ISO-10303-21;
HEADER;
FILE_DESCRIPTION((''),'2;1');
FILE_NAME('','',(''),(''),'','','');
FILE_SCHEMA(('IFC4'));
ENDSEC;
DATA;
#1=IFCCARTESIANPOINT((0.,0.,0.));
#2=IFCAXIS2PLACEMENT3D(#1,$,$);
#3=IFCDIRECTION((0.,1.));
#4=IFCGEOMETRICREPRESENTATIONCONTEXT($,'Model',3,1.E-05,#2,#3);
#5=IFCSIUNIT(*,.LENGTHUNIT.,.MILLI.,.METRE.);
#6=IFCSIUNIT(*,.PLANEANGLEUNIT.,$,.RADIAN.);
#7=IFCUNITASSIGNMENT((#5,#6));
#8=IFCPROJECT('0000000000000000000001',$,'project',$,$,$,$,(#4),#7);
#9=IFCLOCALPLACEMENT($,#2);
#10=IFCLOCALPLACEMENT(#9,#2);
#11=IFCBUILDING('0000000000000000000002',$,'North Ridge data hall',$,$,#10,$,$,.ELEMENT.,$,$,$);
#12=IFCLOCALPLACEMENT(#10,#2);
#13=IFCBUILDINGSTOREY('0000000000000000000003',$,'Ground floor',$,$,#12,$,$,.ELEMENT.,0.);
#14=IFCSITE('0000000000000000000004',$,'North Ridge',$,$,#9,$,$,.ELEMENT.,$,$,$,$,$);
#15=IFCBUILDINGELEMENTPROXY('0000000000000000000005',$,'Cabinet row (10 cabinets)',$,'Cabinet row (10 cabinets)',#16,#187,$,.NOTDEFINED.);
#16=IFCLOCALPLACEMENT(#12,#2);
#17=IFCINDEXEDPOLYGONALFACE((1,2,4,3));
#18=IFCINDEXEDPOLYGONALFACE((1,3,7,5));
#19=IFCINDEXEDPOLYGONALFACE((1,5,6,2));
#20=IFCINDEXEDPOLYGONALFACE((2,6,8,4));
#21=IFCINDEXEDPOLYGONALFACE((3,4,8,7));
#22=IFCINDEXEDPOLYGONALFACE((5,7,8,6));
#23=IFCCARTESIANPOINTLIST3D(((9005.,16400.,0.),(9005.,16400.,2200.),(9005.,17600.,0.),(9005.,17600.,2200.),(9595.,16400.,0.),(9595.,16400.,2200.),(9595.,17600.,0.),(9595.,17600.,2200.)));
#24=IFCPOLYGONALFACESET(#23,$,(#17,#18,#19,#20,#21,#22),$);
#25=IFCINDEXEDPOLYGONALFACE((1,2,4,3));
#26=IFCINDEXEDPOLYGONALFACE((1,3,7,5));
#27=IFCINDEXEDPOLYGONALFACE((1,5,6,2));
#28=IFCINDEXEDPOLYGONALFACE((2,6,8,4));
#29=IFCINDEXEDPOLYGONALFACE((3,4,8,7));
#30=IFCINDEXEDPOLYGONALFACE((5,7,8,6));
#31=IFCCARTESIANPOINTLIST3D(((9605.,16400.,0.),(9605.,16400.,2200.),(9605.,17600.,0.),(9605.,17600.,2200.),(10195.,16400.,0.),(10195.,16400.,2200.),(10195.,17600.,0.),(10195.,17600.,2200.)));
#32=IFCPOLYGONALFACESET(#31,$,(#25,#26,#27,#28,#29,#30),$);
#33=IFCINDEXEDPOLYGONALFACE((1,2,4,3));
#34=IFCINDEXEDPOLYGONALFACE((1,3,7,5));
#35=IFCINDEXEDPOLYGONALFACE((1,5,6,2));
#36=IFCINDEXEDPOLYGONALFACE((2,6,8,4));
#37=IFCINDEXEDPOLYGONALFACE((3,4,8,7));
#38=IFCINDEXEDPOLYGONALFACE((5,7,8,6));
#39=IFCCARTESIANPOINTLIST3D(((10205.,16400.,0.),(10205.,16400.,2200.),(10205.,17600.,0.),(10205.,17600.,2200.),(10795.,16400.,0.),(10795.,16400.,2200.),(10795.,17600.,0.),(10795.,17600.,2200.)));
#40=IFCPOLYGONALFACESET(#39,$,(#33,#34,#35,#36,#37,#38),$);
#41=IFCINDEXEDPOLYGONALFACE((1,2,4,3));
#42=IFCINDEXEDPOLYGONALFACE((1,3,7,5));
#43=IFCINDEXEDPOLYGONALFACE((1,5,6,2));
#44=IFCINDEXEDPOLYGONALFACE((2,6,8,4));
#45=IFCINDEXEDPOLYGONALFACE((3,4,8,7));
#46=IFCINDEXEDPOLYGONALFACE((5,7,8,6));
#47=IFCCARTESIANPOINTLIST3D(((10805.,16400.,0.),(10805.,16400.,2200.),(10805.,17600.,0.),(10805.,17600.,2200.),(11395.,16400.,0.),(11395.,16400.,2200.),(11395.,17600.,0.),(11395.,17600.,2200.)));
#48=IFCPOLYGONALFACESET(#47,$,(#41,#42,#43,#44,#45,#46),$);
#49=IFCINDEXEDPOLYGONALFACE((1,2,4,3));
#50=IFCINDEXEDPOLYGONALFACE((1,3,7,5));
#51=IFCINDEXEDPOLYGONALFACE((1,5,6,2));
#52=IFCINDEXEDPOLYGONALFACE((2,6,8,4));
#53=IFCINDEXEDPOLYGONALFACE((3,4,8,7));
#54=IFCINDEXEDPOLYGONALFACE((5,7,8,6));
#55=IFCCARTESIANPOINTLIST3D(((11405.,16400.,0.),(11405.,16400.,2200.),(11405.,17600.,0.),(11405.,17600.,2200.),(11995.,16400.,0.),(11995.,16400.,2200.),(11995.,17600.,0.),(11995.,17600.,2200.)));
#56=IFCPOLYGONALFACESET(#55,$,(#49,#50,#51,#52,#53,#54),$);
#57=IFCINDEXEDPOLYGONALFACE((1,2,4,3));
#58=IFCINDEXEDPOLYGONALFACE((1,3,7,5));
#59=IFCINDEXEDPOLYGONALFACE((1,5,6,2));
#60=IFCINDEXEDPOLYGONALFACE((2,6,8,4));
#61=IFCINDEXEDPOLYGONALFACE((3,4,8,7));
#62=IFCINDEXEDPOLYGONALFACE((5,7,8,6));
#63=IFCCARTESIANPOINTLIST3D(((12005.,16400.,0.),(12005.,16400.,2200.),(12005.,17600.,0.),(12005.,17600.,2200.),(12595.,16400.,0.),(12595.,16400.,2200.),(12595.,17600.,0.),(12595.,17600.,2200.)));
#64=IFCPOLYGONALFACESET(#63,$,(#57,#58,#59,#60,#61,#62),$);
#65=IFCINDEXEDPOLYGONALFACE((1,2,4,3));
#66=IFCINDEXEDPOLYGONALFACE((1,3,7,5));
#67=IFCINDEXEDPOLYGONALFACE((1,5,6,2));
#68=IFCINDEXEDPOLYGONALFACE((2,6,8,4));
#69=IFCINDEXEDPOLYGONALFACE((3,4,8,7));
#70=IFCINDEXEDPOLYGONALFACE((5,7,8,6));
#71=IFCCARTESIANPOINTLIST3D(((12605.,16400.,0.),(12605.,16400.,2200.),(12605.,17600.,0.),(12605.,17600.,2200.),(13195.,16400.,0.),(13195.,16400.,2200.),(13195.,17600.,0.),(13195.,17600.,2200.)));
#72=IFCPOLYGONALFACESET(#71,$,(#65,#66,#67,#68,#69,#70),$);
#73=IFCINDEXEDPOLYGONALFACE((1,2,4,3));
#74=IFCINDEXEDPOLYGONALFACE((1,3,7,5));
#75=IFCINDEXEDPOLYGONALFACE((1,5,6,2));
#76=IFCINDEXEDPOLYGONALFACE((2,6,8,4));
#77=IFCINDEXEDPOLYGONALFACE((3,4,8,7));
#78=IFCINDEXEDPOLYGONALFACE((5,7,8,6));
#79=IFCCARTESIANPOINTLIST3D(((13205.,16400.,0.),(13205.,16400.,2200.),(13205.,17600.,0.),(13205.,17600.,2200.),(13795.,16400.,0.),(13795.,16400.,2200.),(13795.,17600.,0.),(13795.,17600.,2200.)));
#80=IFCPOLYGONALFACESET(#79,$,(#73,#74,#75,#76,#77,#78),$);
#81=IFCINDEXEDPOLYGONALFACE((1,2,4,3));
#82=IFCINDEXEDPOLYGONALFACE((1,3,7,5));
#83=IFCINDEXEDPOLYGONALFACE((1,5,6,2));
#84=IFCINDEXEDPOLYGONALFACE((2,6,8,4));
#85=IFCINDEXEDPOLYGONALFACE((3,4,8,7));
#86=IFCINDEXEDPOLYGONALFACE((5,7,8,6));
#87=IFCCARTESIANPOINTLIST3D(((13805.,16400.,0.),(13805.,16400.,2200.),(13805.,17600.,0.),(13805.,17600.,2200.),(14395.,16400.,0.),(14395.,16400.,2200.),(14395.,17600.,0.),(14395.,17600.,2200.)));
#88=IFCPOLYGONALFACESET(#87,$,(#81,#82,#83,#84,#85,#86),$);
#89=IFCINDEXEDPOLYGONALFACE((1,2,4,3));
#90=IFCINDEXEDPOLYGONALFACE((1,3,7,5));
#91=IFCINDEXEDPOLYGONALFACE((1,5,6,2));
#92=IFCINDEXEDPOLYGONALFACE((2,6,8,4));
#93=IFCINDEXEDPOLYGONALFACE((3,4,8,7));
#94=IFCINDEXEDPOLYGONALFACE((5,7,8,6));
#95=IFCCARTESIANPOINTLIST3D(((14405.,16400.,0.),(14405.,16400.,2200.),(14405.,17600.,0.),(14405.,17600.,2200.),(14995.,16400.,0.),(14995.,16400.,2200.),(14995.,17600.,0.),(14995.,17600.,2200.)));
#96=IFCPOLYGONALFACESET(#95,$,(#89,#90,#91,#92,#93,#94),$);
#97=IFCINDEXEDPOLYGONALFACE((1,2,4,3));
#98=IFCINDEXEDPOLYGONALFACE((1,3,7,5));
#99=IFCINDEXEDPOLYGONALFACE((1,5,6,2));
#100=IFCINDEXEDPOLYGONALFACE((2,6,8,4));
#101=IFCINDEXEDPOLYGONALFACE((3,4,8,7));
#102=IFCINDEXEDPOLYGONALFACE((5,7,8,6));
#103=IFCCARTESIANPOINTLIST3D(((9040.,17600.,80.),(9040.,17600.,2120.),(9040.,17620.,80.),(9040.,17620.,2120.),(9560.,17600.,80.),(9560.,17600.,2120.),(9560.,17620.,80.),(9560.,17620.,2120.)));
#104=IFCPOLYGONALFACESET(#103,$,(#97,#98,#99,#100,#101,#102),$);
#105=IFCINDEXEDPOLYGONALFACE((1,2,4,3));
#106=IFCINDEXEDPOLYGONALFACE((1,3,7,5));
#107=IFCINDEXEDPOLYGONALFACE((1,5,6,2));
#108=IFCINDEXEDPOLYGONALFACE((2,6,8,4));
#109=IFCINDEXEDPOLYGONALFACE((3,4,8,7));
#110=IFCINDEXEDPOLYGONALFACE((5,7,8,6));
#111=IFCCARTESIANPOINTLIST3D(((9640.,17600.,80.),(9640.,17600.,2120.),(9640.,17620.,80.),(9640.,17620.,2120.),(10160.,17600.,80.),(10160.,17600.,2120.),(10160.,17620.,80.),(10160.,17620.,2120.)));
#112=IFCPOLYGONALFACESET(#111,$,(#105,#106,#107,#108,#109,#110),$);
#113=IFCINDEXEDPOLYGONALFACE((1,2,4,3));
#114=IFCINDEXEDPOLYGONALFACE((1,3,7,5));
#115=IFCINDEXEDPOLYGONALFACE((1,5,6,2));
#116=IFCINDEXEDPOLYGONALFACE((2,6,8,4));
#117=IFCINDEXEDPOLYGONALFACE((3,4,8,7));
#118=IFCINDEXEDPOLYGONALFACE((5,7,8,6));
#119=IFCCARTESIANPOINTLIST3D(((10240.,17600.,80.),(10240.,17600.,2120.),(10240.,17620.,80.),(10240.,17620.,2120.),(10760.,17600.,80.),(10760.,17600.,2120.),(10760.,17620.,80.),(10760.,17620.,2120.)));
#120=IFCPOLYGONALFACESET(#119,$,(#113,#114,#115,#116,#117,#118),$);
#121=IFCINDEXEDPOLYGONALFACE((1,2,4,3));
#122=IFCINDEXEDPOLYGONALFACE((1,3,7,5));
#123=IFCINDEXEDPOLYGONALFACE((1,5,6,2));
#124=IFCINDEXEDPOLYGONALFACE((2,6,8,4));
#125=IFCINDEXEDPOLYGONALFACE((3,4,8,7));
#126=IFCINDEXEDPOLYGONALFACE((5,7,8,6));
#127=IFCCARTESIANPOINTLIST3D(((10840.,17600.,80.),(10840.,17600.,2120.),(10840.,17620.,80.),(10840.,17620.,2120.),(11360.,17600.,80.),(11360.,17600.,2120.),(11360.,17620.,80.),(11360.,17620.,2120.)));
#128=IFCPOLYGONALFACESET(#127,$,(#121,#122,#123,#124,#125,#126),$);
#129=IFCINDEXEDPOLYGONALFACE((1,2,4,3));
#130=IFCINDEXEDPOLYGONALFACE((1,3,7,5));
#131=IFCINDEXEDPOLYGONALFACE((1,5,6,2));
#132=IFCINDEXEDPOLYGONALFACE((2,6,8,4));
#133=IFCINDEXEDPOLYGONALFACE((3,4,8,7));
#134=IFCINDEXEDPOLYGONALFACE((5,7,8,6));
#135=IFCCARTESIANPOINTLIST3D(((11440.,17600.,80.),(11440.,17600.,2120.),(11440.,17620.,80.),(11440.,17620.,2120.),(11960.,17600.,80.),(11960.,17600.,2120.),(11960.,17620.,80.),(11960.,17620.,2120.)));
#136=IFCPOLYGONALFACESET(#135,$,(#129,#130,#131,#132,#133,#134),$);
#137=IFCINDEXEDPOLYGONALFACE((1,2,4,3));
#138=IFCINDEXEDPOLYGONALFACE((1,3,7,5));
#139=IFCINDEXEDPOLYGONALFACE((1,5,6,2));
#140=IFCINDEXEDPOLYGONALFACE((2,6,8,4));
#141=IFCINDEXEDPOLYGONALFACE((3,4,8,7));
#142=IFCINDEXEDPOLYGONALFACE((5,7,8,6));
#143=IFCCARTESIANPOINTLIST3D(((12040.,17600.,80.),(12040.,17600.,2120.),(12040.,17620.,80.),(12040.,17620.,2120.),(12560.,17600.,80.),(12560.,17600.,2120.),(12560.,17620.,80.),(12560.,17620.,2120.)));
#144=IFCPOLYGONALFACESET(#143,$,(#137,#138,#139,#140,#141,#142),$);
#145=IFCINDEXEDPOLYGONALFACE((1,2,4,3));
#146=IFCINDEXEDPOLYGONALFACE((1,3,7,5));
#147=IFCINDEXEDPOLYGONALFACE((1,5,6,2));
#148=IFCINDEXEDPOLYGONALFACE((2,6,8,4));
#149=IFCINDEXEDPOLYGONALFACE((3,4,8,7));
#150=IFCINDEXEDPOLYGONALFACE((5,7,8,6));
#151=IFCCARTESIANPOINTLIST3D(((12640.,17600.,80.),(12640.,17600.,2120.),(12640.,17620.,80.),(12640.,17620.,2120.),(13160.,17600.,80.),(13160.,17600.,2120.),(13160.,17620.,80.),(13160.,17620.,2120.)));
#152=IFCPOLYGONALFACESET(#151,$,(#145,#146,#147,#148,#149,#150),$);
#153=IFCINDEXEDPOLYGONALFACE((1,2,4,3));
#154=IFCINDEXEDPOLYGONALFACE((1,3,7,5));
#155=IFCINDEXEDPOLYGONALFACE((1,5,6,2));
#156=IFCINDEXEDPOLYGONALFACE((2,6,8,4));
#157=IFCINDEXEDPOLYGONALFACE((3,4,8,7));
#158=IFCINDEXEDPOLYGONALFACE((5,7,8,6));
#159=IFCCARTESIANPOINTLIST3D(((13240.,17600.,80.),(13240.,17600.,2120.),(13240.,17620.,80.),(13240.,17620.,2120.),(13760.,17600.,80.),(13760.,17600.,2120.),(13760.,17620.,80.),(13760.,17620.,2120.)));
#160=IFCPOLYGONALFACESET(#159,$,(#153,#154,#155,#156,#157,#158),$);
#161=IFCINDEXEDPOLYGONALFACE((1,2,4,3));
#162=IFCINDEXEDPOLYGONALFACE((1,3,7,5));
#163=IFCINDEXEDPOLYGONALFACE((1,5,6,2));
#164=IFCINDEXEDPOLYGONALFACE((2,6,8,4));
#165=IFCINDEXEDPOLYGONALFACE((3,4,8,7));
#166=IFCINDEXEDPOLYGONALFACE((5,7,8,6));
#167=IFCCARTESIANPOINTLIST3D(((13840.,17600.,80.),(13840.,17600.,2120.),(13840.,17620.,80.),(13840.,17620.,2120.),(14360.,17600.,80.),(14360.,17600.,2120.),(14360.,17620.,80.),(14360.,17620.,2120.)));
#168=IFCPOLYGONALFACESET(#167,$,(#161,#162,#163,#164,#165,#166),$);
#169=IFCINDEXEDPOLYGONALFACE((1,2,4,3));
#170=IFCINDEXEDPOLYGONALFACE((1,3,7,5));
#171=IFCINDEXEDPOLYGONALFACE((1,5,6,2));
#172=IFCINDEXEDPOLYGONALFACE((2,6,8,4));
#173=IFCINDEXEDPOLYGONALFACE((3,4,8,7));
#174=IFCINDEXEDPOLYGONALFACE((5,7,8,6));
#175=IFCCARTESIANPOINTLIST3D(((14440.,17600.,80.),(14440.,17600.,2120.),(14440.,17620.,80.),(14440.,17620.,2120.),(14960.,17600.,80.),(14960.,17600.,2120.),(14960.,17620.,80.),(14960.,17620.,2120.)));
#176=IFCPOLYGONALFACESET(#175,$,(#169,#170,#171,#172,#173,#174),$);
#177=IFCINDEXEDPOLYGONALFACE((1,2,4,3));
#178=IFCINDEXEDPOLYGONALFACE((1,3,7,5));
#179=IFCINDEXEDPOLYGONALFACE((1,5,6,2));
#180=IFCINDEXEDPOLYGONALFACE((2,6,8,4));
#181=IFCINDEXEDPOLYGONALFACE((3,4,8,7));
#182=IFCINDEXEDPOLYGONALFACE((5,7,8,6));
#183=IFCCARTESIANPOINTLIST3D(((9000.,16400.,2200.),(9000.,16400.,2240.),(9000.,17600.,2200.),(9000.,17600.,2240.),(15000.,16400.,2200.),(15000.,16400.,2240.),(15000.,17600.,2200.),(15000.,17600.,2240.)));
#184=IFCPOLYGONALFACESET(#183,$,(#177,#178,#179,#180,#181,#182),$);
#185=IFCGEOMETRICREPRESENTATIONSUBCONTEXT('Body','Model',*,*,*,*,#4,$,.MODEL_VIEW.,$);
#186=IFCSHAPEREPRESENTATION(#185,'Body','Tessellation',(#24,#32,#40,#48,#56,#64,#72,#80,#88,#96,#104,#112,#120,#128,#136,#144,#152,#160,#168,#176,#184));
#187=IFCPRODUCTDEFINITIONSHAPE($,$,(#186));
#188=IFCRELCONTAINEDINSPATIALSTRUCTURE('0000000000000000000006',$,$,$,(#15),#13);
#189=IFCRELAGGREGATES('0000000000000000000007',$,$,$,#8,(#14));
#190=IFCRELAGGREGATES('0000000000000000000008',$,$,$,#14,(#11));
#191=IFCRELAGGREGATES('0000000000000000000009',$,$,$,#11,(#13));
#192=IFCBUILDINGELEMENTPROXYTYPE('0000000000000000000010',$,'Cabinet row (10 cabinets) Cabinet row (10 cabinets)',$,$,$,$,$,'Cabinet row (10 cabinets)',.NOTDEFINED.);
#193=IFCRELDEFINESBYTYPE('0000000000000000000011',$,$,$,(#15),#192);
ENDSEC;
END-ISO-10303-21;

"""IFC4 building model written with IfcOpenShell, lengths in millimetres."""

from ifc_helpers import new_model, si_unit, direction, frame, origin, place, context, subcontext, project, spatial, polyline, outline, extrude, source, transform, mapped, type_object, type_shapes, element, save


model = new_model("IFC4")

# Units and contexts
model_context = context("Model", 3, precision=1e-05, world=origin(), true_north=direction((0.0, 1.0)))
body_context = subcontext(model_context, "Body", "Model", "MODEL_VIEW")
ifc_project = project(units=[si_unit("LENGTHUNIT", "METRE", prefix="MILLI"), si_unit("PLANEANGLEUNIT", "RADIAN")], contexts=[model_context])

# Site, building, storey
site_placement = place(None, origin())
site = spatial("IfcSite", under=ifc_project, at=site_placement, Name="North Ridge", CompositionType="ELEMENT")
building_placement = place(site_placement, origin())
building = spatial("IfcBuilding", under=site, at=building_placement, Name="North Ridge data hall", CompositionType="ELEMENT")
storey_placement = place(building_placement, origin())
storey = spatial("IfcBuildingStorey", under=building, at=storey_placement, Name="Ground floor", CompositionType="ELEMENT", Elevation=0.0)

# Building element proxy
building_element_proxy_type_1 = type_object("IfcBuildingElementProxyType", Name="Cabinet row (10 cabinets) Cabinet row (10 cabinets)", ElementType="Cabinet row (10 cabinets)", PredefinedType="NOTDEFINED")
shared_shape_1 = source(origin(), body_context, "Body", "SweptSolid", [
    extrude(outline(polyline([(5.0, 0.0), (595.0, 0.0), (595.0, 1200.0), (5.0, 1200.0), (5.0, 0.0)])), origin(), (0.0, 0.0, 1.0), 2200.0),
    extrude(outline(polyline([(605.0, 0.0), (1195.0, 0.0), (1195.0, 1200.0), (605.0, 1200.0), (605.0, 0.0)])), origin(), (0.0, 0.0, 1.0), 2200.0),
    extrude(outline(polyline([(1205.0, 0.0), (1795.0, 0.0), (1795.0, 1200.0), (1205.0, 1200.0), (1205.0, 0.0)])), origin(), (0.0, 0.0, 1.0), 2200.0),
    extrude(outline(polyline([(1805.0, 0.0), (2395.0, 0.0), (2395.0, 1200.0), (1805.0, 1200.0), (1805.0, 0.0)])), origin(), (0.0, 0.0, 1.0), 2200.0),
    extrude(outline(polyline([(2405.0, 0.0), (2995.0, 0.0), (2995.0, 1200.0), (2405.0, 1200.0), (2405.0, 0.0)])), origin(), (0.0, 0.0, 1.0), 2200.0),
    extrude(outline(polyline([(3005.0, 0.0), (3595.0, 0.0), (3595.0, 1200.0), (3005.0, 1200.0), (3005.0, 0.0)])), origin(), (0.0, 0.0, 1.0), 2200.0),
    extrude(outline(polyline([(3605.0, 0.0), (4195.0, 0.0), (4195.0, 1200.0), (3605.0, 1200.0), (3605.0, 0.0)])), origin(), (0.0, 0.0, 1.0), 2200.0),
    extrude(outline(polyline([(4205.0, 0.0), (4795.0, 0.0), (4795.0, 1200.0), (4205.0, 1200.0), (4205.0, 0.0)])), origin(), (0.0, 0.0, 1.0), 2200.0),
    extrude(outline(polyline([(4805.0, 0.0), (5395.0, 0.0), (5395.0, 1200.0), (4805.0, 1200.0), (4805.0, 0.0)])), origin(), (0.0, 0.0, 1.0), 2200.0),
    extrude(outline(polyline([(5405.0, 0.0), (5995.0, 0.0), (5995.0, 1200.0), (5405.0, 1200.0), (5405.0, 0.0)])), origin(), (0.0, 0.0, 1.0), 2200.0),
    extrude(outline(polyline([(40.0, 1200.0), (560.0, 1200.0), (560.0, 1220.0), (40.0, 1220.0), (40.0, 1200.0)])), frame((0.0, 0.0, 80.0)), (0.0, 0.0, 1.0), 2040.0),
    extrude(outline(polyline([(640.0, 1200.0), (1160.0, 1200.0), (1160.0, 1220.0), (640.0, 1220.0), (640.0, 1200.0)])), frame((0.0, 0.0, 80.0)), (0.0, 0.0, 1.0), 2040.0),
    extrude(outline(polyline([(1240.0, 1200.0), (1760.0, 1200.0), (1760.0, 1220.0), (1240.0, 1220.0), (1240.0, 1200.0)])), frame((0.0, 0.0, 80.0)), (0.0, 0.0, 1.0), 2040.0),
    extrude(outline(polyline([(1840.0, 1200.0), (2360.0, 1200.0), (2360.0, 1220.0), (1840.0, 1220.0), (1840.0, 1200.0)])), frame((0.0, 0.0, 80.0)), (0.0, 0.0, 1.0), 2040.0),
    extrude(outline(polyline([(2440.0, 1200.0), (2960.0, 1200.0), (2960.0, 1220.0), (2440.0, 1220.0), (2440.0, 1200.0)])), frame((0.0, 0.0, 80.0)), (0.0, 0.0, 1.0), 2040.0),
    extrude(outline(polyline([(3040.0, 1200.0), (3560.0, 1200.0), (3560.0, 1220.0), (3040.0, 1220.0), (3040.0, 1200.0)])), frame((0.0, 0.0, 80.0)), (0.0, 0.0, 1.0), 2040.0),
    extrude(outline(polyline([(3640.0, 1200.0), (4160.0, 1200.0), (4160.0, 1220.0), (3640.0, 1220.0), (3640.0, 1200.0)])), frame((0.0, 0.0, 80.0)), (0.0, 0.0, 1.0), 2040.0),
    extrude(outline(polyline([(4240.0, 1200.0), (4760.0, 1200.0), (4760.0, 1220.0), (4240.0, 1220.0), (4240.0, 1200.0)])), frame((0.0, 0.0, 80.0)), (0.0, 0.0, 1.0), 2040.0),
    extrude(outline(polyline([(4840.0, 1200.0), (5360.0, 1200.0), (5360.0, 1220.0), (4840.0, 1220.0), (4840.0, 1200.0)])), frame((0.0, 0.0, 80.0)), (0.0, 0.0, 1.0), 2040.0),
    extrude(outline(polyline([(5440.0, 1200.0), (5960.0, 1200.0), (5960.0, 1220.0), (5440.0, 1220.0), (5440.0, 1200.0)])), frame((0.0, 0.0, 80.0)), (0.0, 0.0, 1.0), 2040.0),
    extrude(outline(polyline([(0.0, 0.0), (6000.0, 0.0), (6000.0, 1200.0), (0.0, 1200.0), (0.0, 0.0)])), frame((0.0, 0.0, 2200.0)), (0.0, 0.0, 1.0), 40.0),
])
type_shapes(building_element_proxy_type_1, [shared_shape_1])
for number, where, z_axis, x_axis, name in (
    (1, (9000.0, 16400.0, 0.0), (0.0, 0.0, 1.0), (1.0, 0.0, 0.0), "Cabinet row (10 cabinets)"),
):
    element("IfcBuildingElementProxy", number, at=place(storey_placement, frame(where, z_axis=z_axis, x_axis=x_axis)), inside=storey, type_object=building_element_proxy_type_1, Name=name, ObjectType="Cabinet row (10 cabinets)", PredefinedType="NOTDEFINED", context=body_context, shape_type="MappedRepresentation", body=[
        mapped(shared_shape_1, transform((0.0, 0.0, 0.0))),
    ])

save(model, "model.ifc")
